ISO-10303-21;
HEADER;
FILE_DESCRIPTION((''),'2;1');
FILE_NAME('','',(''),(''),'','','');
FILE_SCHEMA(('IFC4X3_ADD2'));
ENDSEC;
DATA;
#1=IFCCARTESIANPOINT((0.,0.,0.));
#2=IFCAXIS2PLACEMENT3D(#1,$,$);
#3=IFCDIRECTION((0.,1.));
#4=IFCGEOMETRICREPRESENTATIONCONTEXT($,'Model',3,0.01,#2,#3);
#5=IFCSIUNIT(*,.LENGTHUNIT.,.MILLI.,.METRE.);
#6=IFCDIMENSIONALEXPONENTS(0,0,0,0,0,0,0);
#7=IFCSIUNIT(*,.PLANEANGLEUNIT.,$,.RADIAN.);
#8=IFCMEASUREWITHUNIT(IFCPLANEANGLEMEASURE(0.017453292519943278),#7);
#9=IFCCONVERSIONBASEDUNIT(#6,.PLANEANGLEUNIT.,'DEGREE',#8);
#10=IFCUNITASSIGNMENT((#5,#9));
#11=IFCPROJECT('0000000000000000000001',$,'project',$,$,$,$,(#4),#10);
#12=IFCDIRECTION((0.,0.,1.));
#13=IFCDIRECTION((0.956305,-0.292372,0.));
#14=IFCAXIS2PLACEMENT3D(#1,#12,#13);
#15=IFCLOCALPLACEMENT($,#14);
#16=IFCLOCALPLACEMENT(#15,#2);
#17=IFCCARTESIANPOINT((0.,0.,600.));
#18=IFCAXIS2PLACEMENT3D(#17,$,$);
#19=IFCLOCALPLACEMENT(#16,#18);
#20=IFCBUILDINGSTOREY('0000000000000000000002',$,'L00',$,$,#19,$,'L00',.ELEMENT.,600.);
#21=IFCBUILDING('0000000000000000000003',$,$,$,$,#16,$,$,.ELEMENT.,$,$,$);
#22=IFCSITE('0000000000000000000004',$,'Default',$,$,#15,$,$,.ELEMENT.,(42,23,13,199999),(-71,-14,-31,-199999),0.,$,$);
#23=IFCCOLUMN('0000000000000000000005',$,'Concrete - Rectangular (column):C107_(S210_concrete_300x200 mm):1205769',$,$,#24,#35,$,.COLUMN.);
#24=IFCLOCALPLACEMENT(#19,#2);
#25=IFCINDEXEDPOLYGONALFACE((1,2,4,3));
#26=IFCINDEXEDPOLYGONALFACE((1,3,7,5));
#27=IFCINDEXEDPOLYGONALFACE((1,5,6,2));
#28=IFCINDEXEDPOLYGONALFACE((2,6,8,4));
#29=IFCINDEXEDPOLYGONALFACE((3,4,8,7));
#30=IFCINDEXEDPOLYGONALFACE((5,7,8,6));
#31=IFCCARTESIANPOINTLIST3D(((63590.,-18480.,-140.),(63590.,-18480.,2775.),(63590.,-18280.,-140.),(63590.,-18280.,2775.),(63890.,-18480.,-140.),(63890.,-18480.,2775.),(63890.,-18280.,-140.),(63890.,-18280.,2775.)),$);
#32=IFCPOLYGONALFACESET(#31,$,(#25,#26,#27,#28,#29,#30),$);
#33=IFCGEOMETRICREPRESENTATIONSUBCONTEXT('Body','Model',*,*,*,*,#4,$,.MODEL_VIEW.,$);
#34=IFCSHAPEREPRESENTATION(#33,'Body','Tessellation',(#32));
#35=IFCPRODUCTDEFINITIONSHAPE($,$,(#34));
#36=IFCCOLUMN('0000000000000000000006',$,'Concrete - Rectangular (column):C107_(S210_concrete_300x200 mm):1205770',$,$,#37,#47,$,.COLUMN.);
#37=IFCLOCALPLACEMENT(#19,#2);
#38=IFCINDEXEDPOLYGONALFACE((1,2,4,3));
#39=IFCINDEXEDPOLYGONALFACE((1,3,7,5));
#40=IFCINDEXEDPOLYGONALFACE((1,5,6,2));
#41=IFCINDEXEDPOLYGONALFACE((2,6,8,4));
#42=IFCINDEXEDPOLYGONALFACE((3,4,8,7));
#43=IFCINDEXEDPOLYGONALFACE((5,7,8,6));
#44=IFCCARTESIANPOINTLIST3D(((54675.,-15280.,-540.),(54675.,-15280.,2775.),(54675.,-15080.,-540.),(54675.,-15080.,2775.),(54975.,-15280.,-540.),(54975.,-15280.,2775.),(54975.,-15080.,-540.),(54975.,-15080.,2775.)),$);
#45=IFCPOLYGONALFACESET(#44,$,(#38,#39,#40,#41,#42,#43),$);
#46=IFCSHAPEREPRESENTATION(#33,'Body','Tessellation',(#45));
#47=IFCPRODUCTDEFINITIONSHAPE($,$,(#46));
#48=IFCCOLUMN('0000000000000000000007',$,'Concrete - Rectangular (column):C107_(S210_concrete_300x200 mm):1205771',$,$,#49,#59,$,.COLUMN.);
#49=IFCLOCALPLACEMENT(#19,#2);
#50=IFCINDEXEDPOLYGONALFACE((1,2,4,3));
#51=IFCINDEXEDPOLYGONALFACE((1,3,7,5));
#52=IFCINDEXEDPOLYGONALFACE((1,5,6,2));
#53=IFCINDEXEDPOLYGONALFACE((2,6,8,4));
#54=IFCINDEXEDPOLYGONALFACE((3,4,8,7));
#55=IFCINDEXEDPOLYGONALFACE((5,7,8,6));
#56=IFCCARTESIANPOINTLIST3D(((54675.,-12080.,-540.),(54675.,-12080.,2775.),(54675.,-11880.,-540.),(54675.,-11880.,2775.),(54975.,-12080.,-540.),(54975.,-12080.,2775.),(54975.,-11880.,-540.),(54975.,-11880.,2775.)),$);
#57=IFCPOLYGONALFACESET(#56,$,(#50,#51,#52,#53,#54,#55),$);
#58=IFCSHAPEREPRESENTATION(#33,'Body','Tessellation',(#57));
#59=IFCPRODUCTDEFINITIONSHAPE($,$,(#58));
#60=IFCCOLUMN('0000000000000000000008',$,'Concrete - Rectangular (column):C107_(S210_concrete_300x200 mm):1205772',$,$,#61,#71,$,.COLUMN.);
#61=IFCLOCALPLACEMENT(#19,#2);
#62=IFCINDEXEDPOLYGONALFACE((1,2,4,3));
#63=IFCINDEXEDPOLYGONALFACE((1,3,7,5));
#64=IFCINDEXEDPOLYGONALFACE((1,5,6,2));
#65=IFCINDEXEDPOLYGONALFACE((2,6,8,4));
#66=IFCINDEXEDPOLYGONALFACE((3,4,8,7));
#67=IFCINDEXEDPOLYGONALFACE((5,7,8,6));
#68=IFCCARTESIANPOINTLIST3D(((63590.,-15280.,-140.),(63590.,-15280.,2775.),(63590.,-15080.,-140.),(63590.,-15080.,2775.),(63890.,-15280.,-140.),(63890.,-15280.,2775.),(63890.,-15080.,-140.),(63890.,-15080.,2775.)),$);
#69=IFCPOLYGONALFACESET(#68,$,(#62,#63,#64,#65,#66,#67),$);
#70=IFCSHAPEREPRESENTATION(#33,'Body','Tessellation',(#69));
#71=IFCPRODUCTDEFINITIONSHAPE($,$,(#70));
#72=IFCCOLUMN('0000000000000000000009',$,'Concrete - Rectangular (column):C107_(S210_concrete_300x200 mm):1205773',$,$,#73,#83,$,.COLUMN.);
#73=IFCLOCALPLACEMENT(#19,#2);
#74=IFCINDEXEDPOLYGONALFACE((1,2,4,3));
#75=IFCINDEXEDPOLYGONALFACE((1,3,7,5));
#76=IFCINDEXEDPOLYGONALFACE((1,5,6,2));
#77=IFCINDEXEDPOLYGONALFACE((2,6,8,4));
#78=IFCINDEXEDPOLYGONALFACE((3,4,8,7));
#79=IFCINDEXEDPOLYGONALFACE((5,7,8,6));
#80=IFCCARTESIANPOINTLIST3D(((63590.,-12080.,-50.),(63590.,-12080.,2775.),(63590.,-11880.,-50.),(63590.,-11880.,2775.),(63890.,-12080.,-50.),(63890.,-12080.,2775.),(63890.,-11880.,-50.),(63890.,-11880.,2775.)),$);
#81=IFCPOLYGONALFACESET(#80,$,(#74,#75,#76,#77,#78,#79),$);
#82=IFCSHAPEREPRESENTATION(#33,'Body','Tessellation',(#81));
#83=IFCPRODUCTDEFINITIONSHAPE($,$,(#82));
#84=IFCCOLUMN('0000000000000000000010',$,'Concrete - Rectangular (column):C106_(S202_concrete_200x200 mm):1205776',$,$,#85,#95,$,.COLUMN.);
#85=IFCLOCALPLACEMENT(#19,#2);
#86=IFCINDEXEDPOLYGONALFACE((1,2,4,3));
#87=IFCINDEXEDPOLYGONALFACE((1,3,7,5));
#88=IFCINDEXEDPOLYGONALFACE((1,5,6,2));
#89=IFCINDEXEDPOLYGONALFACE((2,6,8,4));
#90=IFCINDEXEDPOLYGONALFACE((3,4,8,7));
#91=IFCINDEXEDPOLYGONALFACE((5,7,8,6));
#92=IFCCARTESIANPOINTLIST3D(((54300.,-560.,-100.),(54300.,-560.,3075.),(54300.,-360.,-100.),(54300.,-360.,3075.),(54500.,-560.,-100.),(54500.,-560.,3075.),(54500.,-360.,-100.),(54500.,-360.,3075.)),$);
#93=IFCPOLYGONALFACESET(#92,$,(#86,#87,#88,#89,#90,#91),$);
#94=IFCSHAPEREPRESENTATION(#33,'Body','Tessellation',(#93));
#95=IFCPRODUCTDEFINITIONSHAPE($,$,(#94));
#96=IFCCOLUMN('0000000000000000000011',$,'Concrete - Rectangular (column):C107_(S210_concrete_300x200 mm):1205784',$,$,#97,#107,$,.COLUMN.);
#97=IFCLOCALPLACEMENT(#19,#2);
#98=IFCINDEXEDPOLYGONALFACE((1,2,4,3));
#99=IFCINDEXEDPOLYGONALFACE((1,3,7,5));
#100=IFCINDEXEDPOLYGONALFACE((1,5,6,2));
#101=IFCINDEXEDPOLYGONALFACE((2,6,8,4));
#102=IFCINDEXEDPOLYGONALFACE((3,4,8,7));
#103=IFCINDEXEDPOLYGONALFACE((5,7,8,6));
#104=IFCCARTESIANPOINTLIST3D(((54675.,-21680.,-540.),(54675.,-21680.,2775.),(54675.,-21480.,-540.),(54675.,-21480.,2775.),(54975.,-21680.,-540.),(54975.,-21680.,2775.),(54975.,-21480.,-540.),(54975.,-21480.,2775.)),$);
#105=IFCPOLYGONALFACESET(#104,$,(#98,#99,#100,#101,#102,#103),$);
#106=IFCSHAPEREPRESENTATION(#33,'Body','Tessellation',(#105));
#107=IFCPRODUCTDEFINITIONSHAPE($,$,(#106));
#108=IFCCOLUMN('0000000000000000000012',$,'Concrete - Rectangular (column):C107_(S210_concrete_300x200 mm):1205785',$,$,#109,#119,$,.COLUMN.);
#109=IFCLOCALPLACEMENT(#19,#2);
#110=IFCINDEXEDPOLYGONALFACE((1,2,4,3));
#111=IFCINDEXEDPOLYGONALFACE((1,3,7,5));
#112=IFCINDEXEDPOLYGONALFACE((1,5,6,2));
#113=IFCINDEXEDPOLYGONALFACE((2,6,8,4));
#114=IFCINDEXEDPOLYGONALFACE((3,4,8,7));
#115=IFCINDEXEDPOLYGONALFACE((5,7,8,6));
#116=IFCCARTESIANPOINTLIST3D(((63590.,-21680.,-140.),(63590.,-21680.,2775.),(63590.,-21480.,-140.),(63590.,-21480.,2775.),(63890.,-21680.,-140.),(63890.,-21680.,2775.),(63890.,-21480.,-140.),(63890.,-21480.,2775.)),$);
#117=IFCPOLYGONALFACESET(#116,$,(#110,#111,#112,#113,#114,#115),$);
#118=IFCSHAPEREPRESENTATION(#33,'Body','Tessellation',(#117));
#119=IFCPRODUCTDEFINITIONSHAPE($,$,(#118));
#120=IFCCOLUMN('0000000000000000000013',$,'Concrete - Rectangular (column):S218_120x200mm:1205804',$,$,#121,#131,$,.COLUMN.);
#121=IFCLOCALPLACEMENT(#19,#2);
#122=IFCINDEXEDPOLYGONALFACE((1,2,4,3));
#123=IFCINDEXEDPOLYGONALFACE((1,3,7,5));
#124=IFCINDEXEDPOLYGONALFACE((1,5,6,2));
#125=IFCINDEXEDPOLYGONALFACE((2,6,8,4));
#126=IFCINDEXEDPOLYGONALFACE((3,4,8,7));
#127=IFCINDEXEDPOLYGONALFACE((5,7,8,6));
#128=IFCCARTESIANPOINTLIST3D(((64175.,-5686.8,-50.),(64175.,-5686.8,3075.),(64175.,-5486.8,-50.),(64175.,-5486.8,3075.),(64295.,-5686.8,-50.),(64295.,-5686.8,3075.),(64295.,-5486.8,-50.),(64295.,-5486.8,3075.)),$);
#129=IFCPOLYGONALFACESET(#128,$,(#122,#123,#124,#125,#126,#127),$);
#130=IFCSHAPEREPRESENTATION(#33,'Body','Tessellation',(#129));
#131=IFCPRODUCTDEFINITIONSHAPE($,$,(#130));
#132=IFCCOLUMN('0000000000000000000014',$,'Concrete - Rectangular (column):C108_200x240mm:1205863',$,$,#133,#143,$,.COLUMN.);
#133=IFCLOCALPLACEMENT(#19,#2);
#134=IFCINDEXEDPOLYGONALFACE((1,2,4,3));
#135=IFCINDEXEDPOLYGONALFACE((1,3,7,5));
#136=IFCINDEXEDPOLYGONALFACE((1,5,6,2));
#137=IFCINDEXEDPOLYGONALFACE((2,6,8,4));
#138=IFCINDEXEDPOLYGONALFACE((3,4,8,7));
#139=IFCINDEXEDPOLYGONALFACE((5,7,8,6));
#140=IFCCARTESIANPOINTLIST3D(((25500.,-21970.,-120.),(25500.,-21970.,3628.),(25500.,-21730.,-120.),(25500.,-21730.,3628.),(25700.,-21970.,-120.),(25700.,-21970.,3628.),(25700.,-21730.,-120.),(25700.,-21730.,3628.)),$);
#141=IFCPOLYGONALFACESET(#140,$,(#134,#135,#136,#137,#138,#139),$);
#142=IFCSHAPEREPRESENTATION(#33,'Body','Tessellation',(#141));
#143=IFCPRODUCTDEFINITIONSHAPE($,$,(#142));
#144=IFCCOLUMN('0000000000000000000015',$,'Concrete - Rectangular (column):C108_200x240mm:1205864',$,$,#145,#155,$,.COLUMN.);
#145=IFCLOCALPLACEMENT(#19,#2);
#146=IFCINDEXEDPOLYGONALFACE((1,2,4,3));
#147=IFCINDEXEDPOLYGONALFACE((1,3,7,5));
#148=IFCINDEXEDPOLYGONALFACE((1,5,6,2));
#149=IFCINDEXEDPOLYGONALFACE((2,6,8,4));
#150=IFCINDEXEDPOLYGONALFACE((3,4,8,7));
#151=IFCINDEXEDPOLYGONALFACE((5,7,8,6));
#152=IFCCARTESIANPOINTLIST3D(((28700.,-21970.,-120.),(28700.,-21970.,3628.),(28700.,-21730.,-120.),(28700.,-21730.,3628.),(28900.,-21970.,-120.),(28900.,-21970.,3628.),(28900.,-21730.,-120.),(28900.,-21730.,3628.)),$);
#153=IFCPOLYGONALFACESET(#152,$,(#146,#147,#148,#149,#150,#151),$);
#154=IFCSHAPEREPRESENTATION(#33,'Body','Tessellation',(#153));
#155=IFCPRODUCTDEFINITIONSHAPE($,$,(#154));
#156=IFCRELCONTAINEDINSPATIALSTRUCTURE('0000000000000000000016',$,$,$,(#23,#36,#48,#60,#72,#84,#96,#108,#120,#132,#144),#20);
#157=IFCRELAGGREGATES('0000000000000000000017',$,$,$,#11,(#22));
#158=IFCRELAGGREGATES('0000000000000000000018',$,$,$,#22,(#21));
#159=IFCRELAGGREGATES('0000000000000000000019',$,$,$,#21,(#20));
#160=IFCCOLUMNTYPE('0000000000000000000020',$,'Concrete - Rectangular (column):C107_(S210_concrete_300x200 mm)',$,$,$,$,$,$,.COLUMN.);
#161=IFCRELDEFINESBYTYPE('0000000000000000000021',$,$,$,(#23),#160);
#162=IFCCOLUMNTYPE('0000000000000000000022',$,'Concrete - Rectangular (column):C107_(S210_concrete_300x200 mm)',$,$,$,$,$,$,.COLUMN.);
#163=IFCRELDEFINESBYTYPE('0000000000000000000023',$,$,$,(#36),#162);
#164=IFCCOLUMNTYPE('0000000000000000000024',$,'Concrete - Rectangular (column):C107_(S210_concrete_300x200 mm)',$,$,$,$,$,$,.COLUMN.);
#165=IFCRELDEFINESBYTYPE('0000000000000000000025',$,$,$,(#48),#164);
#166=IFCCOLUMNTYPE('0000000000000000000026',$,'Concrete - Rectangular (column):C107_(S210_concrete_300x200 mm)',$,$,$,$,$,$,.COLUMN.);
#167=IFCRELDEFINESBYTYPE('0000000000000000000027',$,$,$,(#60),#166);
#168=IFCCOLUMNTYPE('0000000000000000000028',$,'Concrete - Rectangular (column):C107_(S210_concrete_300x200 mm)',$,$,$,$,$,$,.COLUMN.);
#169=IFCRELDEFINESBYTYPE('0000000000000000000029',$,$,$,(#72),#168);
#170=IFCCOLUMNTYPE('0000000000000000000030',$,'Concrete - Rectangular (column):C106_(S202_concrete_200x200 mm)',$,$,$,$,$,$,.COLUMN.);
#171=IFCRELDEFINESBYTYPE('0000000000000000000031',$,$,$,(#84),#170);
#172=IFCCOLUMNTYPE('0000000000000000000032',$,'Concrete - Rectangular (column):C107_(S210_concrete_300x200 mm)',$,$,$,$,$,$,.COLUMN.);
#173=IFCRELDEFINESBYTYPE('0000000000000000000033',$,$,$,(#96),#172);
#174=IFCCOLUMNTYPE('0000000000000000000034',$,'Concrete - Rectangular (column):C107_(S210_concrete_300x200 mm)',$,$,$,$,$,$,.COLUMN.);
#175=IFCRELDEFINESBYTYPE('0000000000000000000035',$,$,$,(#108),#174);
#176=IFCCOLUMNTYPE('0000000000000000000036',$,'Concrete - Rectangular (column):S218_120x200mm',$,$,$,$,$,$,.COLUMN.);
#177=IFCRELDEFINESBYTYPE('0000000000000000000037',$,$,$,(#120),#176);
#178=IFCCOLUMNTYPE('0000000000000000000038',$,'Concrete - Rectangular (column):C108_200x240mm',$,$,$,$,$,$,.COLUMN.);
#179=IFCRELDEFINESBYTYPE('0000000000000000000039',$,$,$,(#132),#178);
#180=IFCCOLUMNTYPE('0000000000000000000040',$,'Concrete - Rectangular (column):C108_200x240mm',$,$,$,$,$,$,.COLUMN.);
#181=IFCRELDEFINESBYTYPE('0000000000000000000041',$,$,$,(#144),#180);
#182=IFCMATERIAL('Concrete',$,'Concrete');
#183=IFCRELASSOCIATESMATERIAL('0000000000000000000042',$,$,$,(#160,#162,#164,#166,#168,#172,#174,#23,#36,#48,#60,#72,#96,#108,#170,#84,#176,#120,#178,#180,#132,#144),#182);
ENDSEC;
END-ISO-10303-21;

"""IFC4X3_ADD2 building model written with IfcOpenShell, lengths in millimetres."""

from ifc_helpers import new_model, entity, si_unit, converted_unit, direction, frame, frame_2d, origin, origin_2d_with_axis, place, context, subcontext, project, spatial, rectangle, extrude, source, transform, mapped, material, material_profile, profile_set, profile_usage, type_object, type_shapes, element, save


model = new_model("IFC4X3_ADD2")

# Units and contexts
model_context = context("Model", 3, precision=0.01, world=origin(), true_north=direction((0.0, 1.0)))
body_context = subcontext(model_context, "Body", "Model", "MODEL_VIEW")
ifc_project = project(units=[si_unit("LENGTHUNIT", "METRE", prefix="MILLI"), converted_unit("PLANEANGLEUNIT", "DEGREE", entity("IfcPlaneAngleMeasure", 0.017453292519943278), si_unit("PLANEANGLEUNIT", "RADIAN"), dimensions=[0, 0, 0, 0, 0, 0, 0])], contexts=[model_context])

# Site, building, storey
site_placement = place(None, frame((0.0, 0.0, 0.0), z_axis=(0.0, 0.0, 1.0), x_axis=(0.956305, -0.292372, 0.0)))
site = spatial("IfcSite", under=ifc_project, at=site_placement, Name="Default", CompositionType="ELEMENT", RefLatitude=(42, 23, 13, 199999), RefLongitude=(-71, -14, -31, -199999), RefElevation=0.0)
building_placement = place(site_placement, origin())
building = spatial("IfcBuilding", under=site, at=building_placement, CompositionType="ELEMENT")
storey_placement = place(building_placement, frame((0.0, 0.0, 600.0)))
storey = spatial("IfcBuildingStorey", under=building, at=storey_placement, Name="L00", LongName="L00", CompositionType="ELEMENT", Elevation=600.0)

# Columns
ifc_material_1 = material(Name="Concrete", Category="Concrete")
ifc_material_profile_1 = material_profile(ifc_material_1, rectangle(XDim=300.0, YDim=200.0, at=frame_2d((0.0, 0.0), x_axis=(1.0, 0.0))), Name="C107_(S210_concrete_300x200 mm)")
ifc_profile_set_1 = profile_set([ifc_material_profile_1], Name="C107_(S210_concrete_300x200 mm)")
ifc_profile_usage_1 = profile_usage(ifc_profile_set_1)
column_type_1 = type_object("IfcColumnType", Name="Concrete - Rectangular (column):C107_(S210_concrete_300x200 mm)", PredefinedType="COLUMN", material=ifc_profile_set_1)
shared_shape_1 = source(origin(), body_context, "Body", "SweptSolid", [
    extrude(rectangle(XDim=300.0, YDim=200.0, at=frame_2d((0.0, 0.0), x_axis=(1.0, 0.0))), frame((63740.0, -18380.0, 460.0), z_axis=(0.0, 0.0, 1.0), x_axis=(-1.0, 0.0, 0.0)), (0.0, 0.0, 1.0), 2915.0),
])
type_shapes(column_type_1, [shared_shape_1])
column_1_placement = place(storey_placement, frame((0.0, 0.0, -600.0)))
element("IfcColumn", 1, at=column_1_placement, inside=storey, type_object=column_type_1, material=ifc_profile_usage_1, Name="Concrete - Rectangular (column):C107_(S210_concrete_300x200 mm):1205769", PredefinedType="COLUMN", context=body_context, shape_type="MappedRepresentation", body=[
    mapped(shared_shape_1, transform((0.0, 0.0, 0.0), scale=1.0)),
])
column_type_2 = type_object("IfcColumnType", Name="Concrete - Rectangular (column):C107_(S210_concrete_300x200 mm)", PredefinedType="COLUMN", material=ifc_profile_set_1)
shared_shape_2 = source(origin(), body_context, "Body", "SweptSolid", [
    extrude(rectangle(XDim=300.0, YDim=200.0, at=frame_2d((0.0, 0.0), x_axis=(1.0, 0.0))), frame((54825.0, -15180.0, 60.0), z_axis=(0.0, 0.0, 1.0), x_axis=(-1.0, 0.0, 0.0)), (0.0, 0.0, 1.0), 3315.0),
])
type_shapes(column_type_2, [shared_shape_2])
column_2_placement = place(storey_placement, frame((0.0, 0.0, -600.0)))
element("IfcColumn", 2, at=column_2_placement, inside=storey, type_object=column_type_2, material=ifc_profile_usage_1, Name="Concrete - Rectangular (column):C107_(S210_concrete_300x200 mm):1205770", PredefinedType="COLUMN", context=body_context, shape_type="MappedRepresentation", body=[
    mapped(shared_shape_2, transform((0.0, 0.0, 0.0), scale=1.0)),
])
column_type_3 = type_object("IfcColumnType", Name="Concrete - Rectangular (column):C107_(S210_concrete_300x200 mm)", PredefinedType="COLUMN", material=ifc_profile_set_1)
shared_shape_3 = source(origin(), body_context, "Body", "SweptSolid", [
    extrude(rectangle(XDim=200.0, YDim=300.0, at=frame_2d((0.0, 0.0), x_axis=(1.0, 0.0))), frame((54825.0, -11980.0, 60.0), z_axis=(0.0, 0.0, 1.0), x_axis=(0.0, 1.0, 0.0)), (0.0, 0.0, 1.0), 3315.0),
])
type_shapes(column_type_3, [shared_shape_3])
column_3_placement = place(storey_placement, frame((0.0, 0.0, -600.0)))
element("IfcColumn", 3, at=column_3_placement, inside=storey, type_object=column_type_3, material=ifc_profile_usage_1, Name="Concrete - Rectangular (column):C107_(S210_concrete_300x200 mm):1205771", PredefinedType="COLUMN", context=body_context, shape_type="MappedRepresentation", body=[
    mapped(shared_shape_3, transform((0.0, 0.0, 0.0), scale=1.0)),
])
column_type_4 = type_object("IfcColumnType", Name="Concrete - Rectangular (column):C107_(S210_concrete_300x200 mm)", PredefinedType="COLUMN", material=ifc_profile_set_1)
shared_shape_4 = source(origin(), body_context, "Body", "SweptSolid", [
    extrude(rectangle(XDim=300.0, YDim=200.0, at=frame_2d((0.0, 0.0), x_axis=(1.0, 0.0))), frame((63740.0, -15180.0, 460.0), z_axis=(0.0, 0.0, 1.0), x_axis=(-1.0, 0.0, 0.0)), (0.0, 0.0, 1.0), 2915.0),
])
type_shapes(column_type_4, [shared_shape_4])
column_4_placement = place(storey_placement, frame((0.0, 0.0, -600.0)))
element("IfcColumn", 4, at=column_4_placement, inside=storey, type_object=column_type_4, material=ifc_profile_usage_1, Name="Concrete - Rectangular (column):C107_(S210_concrete_300x200 mm):1205772", PredefinedType="COLUMN", context=body_context, shape_type="MappedRepresentation", body=[
    mapped(shared_shape_4, transform((0.0, 0.0, 0.0), scale=1.0)),
])
column_type_5 = type_object("IfcColumnType", Name="Concrete - Rectangular (column):C107_(S210_concrete_300x200 mm)", PredefinedType="COLUMN", material=ifc_profile_set_1)
shared_shape_5 = source(origin(), body_context, "Body", "SweptSolid", [
    extrude(rectangle(XDim=200.0, YDim=300.0, at=frame_2d((0.0, 0.0), x_axis=(1.0, 0.0))), frame((63740.0, -11980.0, 550.0), z_axis=(0.0, 0.0, 1.0), x_axis=(0.0, 1.0, 0.0)), (0.0, 0.0, 1.0), 2825.0),
])
type_shapes(column_type_5, [shared_shape_5])
column_5_placement = place(storey_placement, frame((0.0, 0.0, -600.0)))
element("IfcColumn", 5, at=column_5_placement, inside=storey, type_object=column_type_5, material=ifc_profile_usage_1, Name="Concrete - Rectangular (column):C107_(S210_concrete_300x200 mm):1205773", PredefinedType="COLUMN", context=body_context, shape_type="MappedRepresentation", body=[
    mapped(shared_shape_5, transform((0.0, 0.0, 0.0), scale=1.0)),
])
ifc_material_profile_2 = material_profile(ifc_material_1, rectangle(XDim=200.0, YDim=200.0, at=frame_2d((0.0, 0.0), x_axis=(1.0, 0.0))), Name="C106_(S202_concrete_200x200 mm)")
ifc_profile_set_2 = profile_set([ifc_material_profile_2], Name="C106_(S202_concrete_200x200 mm)")
ifc_profile_usage_2 = profile_usage(ifc_profile_set_2)
column_type_6 = type_object("IfcColumnType", Name="Concrete - Rectangular (column):C106_(S202_concrete_200x200 mm)", PredefinedType="COLUMN", material=ifc_profile_set_2)
shared_shape_6 = source(origin(), body_context, "Body", "SweptSolid", [
    extrude(rectangle(XDim=200.0, YDim=200.0, at=frame_2d((0.0, 0.0), x_axis=(1.0, 0.0))), frame((54400.0, -460.0, 500.0), z_axis=(0.0, 0.0, 1.0), x_axis=(0.0, 1.0, 0.0)), (0.0, 0.0, 1.0), 3175.0),
])
type_shapes(column_type_6, [shared_shape_6])
column_6_placement = place(storey_placement, frame((0.0, 0.0, -600.0)))
element("IfcColumn", 6, at=column_6_placement, inside=storey, type_object=column_type_6, material=ifc_profile_usage_2, Name="Concrete - Rectangular (column):C106_(S202_concrete_200x200 mm):1205776", PredefinedType="COLUMN", context=body_context, shape_type="MappedRepresentation", body=[
    mapped(shared_shape_6, transform((0.0, 0.0, 0.0), scale=1.0)),
])
column_type_7 = type_object("IfcColumnType", Name="Concrete - Rectangular (column):C107_(S210_concrete_300x200 mm)", PredefinedType="COLUMN", material=ifc_profile_set_1)
shared_shape_7 = source(origin(), body_context, "Body", "SweptSolid", [
    extrude(rectangle(XDim=300.0, YDim=200.0, at=origin_2d_with_axis()), frame((54825.0, -21580.0, 60.0), z_axis=(0.0, 0.0, 1.0), x_axis=(-1.0, 0.0, 0.0)), (0.0, 0.0, 1.0), 3315.0),
])
type_shapes(column_type_7, [shared_shape_7])
column_7_placement = place(storey_placement, frame((0.0, 0.0, -600.0)))
element("IfcColumn", 7, at=column_7_placement, inside=storey, type_object=column_type_7, material=ifc_profile_usage_1, Name="Concrete - Rectangular (column):C107_(S210_concrete_300x200 mm):1205784", PredefinedType="COLUMN", context=body_context, shape_type="MappedRepresentation", body=[
    mapped(shared_shape_7, transform((0.0, 0.0, 0.0), scale=1.0)),
])
column_type_8 = type_object("IfcColumnType", Name="Concrete - Rectangular (column):C107_(S210_concrete_300x200 mm)", PredefinedType="COLUMN", material=ifc_profile_set_1)
shared_shape_8 = source(origin(), body_context, "Body", "SweptSolid", [
    extrude(rectangle(XDim=300.0, YDim=200.0, at=origin_2d_with_axis()), frame((63740.0, -21580.0, 460.0), z_axis=(0.0, 0.0, 1.0), x_axis=(-1.0, 0.0, 0.0)), (0.0, 0.0, 1.0), 2915.0),
])
type_shapes(column_type_8, [shared_shape_8])
column_8_placement = place(storey_placement, frame((0.0, 0.0, -600.0)))
element("IfcColumn", 8, at=column_8_placement, inside=storey, type_object=column_type_8, material=ifc_profile_usage_1, Name="Concrete - Rectangular (column):C107_(S210_concrete_300x200 mm):1205785", PredefinedType="COLUMN", context=body_context, shape_type="MappedRepresentation", body=[
    mapped(shared_shape_8, transform((0.0, 0.0, 0.0), scale=1.0)),
])
ifc_material_profile_3 = material_profile(ifc_material_1, rectangle(XDim=120.0, YDim=200.0, at=frame_2d((0.0, 0.0), x_axis=(1.0, 0.0))), Name="S218_120x200mm")
ifc_profile_set_3 = profile_set([ifc_material_profile_3], Name="S218_120x200mm")
ifc_profile_usage_3 = profile_usage(ifc_profile_set_3)
column_type_9 = type_object("IfcColumnType", Name="Concrete - Rectangular (column):S218_120x200mm", PredefinedType="COLUMN", material=ifc_profile_set_3)
shared_shape_9 = source(origin(), body_context, "Body", "SweptSolid", [
    extrude(rectangle(XDim=120.0, YDim=200.0, at=frame_2d((0.0, 0.0), x_axis=(1.0, 0.0))), frame((64235.0, -5586.8, 550.0), z_axis=(0.0, 0.0, 1.0), x_axis=(-1.0, 0.0, 0.0)), (0.0, 0.0, 1.0), 3125.0),
])
type_shapes(column_type_9, [shared_shape_9])
column_9_placement = place(storey_placement, frame((0.0, 0.0, -600.0)))
element("IfcColumn", 9, at=column_9_placement, inside=storey, type_object=column_type_9, material=ifc_profile_usage_3, Name="Concrete - Rectangular (column):S218_120x200mm:1205804", PredefinedType="COLUMN", context=body_context, shape_type="MappedRepresentation", body=[
    mapped(shared_shape_9, transform((0.0, 0.0, 0.0), scale=1.0)),
])
ifc_material_profile_4 = material_profile(ifc_material_1, rectangle(XDim=200.0, YDim=240.0, at=frame_2d((0.0, 0.0), x_axis=(1.0, 0.0))), Name="C108_200x240mm")
ifc_profile_set_4 = profile_set([ifc_material_profile_4], Name="C108_200x240mm")
ifc_profile_usage_4 = profile_usage(ifc_profile_set_4)
column_type_10 = type_object("IfcColumnType", Name="Concrete - Rectangular (column):C108_200x240mm", PredefinedType="COLUMN", material=ifc_profile_set_4)
shared_shape_10 = source(origin(), body_context, "Body", "SweptSolid", [
    extrude(rectangle(XDim=200.0, YDim=240.0, at=frame_2d((0.0, 0.0), x_axis=(1.0, 0.0))), frame((25600.0, -21850.0, 480.0), z_axis=(0.0, 0.0, 1.0), x_axis=(-1.0, 0.0, 0.0)), (0.0, 0.0, 1.0), 3748.0),
])
type_shapes(column_type_10, [shared_shape_10])
column_10_placement = place(storey_placement, frame((0.0, 0.0, -600.0)))
element("IfcColumn", 10, at=column_10_placement, inside=storey, type_object=column_type_10, material=ifc_profile_usage_4, Name="Concrete - Rectangular (column):C108_200x240mm:1205863", PredefinedType="COLUMN", context=body_context, shape_type="MappedRepresentation", body=[
    mapped(shared_shape_10, transform((0.0, 0.0, 0.0), scale=1.0)),
])
column_type_11 = type_object("IfcColumnType", Name="Concrete - Rectangular (column):C108_200x240mm", PredefinedType="COLUMN", material=ifc_profile_set_4)
shared_shape_11 = source(origin(), body_context, "Body", "SweptSolid", [
    extrude(rectangle(XDim=200.0, YDim=240.0, at=frame_2d((0.0, 0.0), x_axis=(1.0, 0.0))), frame((28800.0, -21850.0, 480.0), z_axis=(0.0, 0.0, 1.0), x_axis=(-1.0, 0.0, 0.0)), (0.0, 0.0, 1.0), 3748.0),
])
type_shapes(column_type_11, [shared_shape_11])
column_11_placement = place(storey_placement, frame((0.0, 0.0, -600.0)))
element("IfcColumn", 11, at=column_11_placement, inside=storey, type_object=column_type_11, material=ifc_profile_usage_4, Name="Concrete - Rectangular (column):C108_200x240mm:1205864", PredefinedType="COLUMN", context=body_context, shape_type="MappedRepresentation", body=[
    mapped(shared_shape_11, transform((0.0, 0.0, 0.0), scale=1.0)),
])

save(model, "model.ifc")
